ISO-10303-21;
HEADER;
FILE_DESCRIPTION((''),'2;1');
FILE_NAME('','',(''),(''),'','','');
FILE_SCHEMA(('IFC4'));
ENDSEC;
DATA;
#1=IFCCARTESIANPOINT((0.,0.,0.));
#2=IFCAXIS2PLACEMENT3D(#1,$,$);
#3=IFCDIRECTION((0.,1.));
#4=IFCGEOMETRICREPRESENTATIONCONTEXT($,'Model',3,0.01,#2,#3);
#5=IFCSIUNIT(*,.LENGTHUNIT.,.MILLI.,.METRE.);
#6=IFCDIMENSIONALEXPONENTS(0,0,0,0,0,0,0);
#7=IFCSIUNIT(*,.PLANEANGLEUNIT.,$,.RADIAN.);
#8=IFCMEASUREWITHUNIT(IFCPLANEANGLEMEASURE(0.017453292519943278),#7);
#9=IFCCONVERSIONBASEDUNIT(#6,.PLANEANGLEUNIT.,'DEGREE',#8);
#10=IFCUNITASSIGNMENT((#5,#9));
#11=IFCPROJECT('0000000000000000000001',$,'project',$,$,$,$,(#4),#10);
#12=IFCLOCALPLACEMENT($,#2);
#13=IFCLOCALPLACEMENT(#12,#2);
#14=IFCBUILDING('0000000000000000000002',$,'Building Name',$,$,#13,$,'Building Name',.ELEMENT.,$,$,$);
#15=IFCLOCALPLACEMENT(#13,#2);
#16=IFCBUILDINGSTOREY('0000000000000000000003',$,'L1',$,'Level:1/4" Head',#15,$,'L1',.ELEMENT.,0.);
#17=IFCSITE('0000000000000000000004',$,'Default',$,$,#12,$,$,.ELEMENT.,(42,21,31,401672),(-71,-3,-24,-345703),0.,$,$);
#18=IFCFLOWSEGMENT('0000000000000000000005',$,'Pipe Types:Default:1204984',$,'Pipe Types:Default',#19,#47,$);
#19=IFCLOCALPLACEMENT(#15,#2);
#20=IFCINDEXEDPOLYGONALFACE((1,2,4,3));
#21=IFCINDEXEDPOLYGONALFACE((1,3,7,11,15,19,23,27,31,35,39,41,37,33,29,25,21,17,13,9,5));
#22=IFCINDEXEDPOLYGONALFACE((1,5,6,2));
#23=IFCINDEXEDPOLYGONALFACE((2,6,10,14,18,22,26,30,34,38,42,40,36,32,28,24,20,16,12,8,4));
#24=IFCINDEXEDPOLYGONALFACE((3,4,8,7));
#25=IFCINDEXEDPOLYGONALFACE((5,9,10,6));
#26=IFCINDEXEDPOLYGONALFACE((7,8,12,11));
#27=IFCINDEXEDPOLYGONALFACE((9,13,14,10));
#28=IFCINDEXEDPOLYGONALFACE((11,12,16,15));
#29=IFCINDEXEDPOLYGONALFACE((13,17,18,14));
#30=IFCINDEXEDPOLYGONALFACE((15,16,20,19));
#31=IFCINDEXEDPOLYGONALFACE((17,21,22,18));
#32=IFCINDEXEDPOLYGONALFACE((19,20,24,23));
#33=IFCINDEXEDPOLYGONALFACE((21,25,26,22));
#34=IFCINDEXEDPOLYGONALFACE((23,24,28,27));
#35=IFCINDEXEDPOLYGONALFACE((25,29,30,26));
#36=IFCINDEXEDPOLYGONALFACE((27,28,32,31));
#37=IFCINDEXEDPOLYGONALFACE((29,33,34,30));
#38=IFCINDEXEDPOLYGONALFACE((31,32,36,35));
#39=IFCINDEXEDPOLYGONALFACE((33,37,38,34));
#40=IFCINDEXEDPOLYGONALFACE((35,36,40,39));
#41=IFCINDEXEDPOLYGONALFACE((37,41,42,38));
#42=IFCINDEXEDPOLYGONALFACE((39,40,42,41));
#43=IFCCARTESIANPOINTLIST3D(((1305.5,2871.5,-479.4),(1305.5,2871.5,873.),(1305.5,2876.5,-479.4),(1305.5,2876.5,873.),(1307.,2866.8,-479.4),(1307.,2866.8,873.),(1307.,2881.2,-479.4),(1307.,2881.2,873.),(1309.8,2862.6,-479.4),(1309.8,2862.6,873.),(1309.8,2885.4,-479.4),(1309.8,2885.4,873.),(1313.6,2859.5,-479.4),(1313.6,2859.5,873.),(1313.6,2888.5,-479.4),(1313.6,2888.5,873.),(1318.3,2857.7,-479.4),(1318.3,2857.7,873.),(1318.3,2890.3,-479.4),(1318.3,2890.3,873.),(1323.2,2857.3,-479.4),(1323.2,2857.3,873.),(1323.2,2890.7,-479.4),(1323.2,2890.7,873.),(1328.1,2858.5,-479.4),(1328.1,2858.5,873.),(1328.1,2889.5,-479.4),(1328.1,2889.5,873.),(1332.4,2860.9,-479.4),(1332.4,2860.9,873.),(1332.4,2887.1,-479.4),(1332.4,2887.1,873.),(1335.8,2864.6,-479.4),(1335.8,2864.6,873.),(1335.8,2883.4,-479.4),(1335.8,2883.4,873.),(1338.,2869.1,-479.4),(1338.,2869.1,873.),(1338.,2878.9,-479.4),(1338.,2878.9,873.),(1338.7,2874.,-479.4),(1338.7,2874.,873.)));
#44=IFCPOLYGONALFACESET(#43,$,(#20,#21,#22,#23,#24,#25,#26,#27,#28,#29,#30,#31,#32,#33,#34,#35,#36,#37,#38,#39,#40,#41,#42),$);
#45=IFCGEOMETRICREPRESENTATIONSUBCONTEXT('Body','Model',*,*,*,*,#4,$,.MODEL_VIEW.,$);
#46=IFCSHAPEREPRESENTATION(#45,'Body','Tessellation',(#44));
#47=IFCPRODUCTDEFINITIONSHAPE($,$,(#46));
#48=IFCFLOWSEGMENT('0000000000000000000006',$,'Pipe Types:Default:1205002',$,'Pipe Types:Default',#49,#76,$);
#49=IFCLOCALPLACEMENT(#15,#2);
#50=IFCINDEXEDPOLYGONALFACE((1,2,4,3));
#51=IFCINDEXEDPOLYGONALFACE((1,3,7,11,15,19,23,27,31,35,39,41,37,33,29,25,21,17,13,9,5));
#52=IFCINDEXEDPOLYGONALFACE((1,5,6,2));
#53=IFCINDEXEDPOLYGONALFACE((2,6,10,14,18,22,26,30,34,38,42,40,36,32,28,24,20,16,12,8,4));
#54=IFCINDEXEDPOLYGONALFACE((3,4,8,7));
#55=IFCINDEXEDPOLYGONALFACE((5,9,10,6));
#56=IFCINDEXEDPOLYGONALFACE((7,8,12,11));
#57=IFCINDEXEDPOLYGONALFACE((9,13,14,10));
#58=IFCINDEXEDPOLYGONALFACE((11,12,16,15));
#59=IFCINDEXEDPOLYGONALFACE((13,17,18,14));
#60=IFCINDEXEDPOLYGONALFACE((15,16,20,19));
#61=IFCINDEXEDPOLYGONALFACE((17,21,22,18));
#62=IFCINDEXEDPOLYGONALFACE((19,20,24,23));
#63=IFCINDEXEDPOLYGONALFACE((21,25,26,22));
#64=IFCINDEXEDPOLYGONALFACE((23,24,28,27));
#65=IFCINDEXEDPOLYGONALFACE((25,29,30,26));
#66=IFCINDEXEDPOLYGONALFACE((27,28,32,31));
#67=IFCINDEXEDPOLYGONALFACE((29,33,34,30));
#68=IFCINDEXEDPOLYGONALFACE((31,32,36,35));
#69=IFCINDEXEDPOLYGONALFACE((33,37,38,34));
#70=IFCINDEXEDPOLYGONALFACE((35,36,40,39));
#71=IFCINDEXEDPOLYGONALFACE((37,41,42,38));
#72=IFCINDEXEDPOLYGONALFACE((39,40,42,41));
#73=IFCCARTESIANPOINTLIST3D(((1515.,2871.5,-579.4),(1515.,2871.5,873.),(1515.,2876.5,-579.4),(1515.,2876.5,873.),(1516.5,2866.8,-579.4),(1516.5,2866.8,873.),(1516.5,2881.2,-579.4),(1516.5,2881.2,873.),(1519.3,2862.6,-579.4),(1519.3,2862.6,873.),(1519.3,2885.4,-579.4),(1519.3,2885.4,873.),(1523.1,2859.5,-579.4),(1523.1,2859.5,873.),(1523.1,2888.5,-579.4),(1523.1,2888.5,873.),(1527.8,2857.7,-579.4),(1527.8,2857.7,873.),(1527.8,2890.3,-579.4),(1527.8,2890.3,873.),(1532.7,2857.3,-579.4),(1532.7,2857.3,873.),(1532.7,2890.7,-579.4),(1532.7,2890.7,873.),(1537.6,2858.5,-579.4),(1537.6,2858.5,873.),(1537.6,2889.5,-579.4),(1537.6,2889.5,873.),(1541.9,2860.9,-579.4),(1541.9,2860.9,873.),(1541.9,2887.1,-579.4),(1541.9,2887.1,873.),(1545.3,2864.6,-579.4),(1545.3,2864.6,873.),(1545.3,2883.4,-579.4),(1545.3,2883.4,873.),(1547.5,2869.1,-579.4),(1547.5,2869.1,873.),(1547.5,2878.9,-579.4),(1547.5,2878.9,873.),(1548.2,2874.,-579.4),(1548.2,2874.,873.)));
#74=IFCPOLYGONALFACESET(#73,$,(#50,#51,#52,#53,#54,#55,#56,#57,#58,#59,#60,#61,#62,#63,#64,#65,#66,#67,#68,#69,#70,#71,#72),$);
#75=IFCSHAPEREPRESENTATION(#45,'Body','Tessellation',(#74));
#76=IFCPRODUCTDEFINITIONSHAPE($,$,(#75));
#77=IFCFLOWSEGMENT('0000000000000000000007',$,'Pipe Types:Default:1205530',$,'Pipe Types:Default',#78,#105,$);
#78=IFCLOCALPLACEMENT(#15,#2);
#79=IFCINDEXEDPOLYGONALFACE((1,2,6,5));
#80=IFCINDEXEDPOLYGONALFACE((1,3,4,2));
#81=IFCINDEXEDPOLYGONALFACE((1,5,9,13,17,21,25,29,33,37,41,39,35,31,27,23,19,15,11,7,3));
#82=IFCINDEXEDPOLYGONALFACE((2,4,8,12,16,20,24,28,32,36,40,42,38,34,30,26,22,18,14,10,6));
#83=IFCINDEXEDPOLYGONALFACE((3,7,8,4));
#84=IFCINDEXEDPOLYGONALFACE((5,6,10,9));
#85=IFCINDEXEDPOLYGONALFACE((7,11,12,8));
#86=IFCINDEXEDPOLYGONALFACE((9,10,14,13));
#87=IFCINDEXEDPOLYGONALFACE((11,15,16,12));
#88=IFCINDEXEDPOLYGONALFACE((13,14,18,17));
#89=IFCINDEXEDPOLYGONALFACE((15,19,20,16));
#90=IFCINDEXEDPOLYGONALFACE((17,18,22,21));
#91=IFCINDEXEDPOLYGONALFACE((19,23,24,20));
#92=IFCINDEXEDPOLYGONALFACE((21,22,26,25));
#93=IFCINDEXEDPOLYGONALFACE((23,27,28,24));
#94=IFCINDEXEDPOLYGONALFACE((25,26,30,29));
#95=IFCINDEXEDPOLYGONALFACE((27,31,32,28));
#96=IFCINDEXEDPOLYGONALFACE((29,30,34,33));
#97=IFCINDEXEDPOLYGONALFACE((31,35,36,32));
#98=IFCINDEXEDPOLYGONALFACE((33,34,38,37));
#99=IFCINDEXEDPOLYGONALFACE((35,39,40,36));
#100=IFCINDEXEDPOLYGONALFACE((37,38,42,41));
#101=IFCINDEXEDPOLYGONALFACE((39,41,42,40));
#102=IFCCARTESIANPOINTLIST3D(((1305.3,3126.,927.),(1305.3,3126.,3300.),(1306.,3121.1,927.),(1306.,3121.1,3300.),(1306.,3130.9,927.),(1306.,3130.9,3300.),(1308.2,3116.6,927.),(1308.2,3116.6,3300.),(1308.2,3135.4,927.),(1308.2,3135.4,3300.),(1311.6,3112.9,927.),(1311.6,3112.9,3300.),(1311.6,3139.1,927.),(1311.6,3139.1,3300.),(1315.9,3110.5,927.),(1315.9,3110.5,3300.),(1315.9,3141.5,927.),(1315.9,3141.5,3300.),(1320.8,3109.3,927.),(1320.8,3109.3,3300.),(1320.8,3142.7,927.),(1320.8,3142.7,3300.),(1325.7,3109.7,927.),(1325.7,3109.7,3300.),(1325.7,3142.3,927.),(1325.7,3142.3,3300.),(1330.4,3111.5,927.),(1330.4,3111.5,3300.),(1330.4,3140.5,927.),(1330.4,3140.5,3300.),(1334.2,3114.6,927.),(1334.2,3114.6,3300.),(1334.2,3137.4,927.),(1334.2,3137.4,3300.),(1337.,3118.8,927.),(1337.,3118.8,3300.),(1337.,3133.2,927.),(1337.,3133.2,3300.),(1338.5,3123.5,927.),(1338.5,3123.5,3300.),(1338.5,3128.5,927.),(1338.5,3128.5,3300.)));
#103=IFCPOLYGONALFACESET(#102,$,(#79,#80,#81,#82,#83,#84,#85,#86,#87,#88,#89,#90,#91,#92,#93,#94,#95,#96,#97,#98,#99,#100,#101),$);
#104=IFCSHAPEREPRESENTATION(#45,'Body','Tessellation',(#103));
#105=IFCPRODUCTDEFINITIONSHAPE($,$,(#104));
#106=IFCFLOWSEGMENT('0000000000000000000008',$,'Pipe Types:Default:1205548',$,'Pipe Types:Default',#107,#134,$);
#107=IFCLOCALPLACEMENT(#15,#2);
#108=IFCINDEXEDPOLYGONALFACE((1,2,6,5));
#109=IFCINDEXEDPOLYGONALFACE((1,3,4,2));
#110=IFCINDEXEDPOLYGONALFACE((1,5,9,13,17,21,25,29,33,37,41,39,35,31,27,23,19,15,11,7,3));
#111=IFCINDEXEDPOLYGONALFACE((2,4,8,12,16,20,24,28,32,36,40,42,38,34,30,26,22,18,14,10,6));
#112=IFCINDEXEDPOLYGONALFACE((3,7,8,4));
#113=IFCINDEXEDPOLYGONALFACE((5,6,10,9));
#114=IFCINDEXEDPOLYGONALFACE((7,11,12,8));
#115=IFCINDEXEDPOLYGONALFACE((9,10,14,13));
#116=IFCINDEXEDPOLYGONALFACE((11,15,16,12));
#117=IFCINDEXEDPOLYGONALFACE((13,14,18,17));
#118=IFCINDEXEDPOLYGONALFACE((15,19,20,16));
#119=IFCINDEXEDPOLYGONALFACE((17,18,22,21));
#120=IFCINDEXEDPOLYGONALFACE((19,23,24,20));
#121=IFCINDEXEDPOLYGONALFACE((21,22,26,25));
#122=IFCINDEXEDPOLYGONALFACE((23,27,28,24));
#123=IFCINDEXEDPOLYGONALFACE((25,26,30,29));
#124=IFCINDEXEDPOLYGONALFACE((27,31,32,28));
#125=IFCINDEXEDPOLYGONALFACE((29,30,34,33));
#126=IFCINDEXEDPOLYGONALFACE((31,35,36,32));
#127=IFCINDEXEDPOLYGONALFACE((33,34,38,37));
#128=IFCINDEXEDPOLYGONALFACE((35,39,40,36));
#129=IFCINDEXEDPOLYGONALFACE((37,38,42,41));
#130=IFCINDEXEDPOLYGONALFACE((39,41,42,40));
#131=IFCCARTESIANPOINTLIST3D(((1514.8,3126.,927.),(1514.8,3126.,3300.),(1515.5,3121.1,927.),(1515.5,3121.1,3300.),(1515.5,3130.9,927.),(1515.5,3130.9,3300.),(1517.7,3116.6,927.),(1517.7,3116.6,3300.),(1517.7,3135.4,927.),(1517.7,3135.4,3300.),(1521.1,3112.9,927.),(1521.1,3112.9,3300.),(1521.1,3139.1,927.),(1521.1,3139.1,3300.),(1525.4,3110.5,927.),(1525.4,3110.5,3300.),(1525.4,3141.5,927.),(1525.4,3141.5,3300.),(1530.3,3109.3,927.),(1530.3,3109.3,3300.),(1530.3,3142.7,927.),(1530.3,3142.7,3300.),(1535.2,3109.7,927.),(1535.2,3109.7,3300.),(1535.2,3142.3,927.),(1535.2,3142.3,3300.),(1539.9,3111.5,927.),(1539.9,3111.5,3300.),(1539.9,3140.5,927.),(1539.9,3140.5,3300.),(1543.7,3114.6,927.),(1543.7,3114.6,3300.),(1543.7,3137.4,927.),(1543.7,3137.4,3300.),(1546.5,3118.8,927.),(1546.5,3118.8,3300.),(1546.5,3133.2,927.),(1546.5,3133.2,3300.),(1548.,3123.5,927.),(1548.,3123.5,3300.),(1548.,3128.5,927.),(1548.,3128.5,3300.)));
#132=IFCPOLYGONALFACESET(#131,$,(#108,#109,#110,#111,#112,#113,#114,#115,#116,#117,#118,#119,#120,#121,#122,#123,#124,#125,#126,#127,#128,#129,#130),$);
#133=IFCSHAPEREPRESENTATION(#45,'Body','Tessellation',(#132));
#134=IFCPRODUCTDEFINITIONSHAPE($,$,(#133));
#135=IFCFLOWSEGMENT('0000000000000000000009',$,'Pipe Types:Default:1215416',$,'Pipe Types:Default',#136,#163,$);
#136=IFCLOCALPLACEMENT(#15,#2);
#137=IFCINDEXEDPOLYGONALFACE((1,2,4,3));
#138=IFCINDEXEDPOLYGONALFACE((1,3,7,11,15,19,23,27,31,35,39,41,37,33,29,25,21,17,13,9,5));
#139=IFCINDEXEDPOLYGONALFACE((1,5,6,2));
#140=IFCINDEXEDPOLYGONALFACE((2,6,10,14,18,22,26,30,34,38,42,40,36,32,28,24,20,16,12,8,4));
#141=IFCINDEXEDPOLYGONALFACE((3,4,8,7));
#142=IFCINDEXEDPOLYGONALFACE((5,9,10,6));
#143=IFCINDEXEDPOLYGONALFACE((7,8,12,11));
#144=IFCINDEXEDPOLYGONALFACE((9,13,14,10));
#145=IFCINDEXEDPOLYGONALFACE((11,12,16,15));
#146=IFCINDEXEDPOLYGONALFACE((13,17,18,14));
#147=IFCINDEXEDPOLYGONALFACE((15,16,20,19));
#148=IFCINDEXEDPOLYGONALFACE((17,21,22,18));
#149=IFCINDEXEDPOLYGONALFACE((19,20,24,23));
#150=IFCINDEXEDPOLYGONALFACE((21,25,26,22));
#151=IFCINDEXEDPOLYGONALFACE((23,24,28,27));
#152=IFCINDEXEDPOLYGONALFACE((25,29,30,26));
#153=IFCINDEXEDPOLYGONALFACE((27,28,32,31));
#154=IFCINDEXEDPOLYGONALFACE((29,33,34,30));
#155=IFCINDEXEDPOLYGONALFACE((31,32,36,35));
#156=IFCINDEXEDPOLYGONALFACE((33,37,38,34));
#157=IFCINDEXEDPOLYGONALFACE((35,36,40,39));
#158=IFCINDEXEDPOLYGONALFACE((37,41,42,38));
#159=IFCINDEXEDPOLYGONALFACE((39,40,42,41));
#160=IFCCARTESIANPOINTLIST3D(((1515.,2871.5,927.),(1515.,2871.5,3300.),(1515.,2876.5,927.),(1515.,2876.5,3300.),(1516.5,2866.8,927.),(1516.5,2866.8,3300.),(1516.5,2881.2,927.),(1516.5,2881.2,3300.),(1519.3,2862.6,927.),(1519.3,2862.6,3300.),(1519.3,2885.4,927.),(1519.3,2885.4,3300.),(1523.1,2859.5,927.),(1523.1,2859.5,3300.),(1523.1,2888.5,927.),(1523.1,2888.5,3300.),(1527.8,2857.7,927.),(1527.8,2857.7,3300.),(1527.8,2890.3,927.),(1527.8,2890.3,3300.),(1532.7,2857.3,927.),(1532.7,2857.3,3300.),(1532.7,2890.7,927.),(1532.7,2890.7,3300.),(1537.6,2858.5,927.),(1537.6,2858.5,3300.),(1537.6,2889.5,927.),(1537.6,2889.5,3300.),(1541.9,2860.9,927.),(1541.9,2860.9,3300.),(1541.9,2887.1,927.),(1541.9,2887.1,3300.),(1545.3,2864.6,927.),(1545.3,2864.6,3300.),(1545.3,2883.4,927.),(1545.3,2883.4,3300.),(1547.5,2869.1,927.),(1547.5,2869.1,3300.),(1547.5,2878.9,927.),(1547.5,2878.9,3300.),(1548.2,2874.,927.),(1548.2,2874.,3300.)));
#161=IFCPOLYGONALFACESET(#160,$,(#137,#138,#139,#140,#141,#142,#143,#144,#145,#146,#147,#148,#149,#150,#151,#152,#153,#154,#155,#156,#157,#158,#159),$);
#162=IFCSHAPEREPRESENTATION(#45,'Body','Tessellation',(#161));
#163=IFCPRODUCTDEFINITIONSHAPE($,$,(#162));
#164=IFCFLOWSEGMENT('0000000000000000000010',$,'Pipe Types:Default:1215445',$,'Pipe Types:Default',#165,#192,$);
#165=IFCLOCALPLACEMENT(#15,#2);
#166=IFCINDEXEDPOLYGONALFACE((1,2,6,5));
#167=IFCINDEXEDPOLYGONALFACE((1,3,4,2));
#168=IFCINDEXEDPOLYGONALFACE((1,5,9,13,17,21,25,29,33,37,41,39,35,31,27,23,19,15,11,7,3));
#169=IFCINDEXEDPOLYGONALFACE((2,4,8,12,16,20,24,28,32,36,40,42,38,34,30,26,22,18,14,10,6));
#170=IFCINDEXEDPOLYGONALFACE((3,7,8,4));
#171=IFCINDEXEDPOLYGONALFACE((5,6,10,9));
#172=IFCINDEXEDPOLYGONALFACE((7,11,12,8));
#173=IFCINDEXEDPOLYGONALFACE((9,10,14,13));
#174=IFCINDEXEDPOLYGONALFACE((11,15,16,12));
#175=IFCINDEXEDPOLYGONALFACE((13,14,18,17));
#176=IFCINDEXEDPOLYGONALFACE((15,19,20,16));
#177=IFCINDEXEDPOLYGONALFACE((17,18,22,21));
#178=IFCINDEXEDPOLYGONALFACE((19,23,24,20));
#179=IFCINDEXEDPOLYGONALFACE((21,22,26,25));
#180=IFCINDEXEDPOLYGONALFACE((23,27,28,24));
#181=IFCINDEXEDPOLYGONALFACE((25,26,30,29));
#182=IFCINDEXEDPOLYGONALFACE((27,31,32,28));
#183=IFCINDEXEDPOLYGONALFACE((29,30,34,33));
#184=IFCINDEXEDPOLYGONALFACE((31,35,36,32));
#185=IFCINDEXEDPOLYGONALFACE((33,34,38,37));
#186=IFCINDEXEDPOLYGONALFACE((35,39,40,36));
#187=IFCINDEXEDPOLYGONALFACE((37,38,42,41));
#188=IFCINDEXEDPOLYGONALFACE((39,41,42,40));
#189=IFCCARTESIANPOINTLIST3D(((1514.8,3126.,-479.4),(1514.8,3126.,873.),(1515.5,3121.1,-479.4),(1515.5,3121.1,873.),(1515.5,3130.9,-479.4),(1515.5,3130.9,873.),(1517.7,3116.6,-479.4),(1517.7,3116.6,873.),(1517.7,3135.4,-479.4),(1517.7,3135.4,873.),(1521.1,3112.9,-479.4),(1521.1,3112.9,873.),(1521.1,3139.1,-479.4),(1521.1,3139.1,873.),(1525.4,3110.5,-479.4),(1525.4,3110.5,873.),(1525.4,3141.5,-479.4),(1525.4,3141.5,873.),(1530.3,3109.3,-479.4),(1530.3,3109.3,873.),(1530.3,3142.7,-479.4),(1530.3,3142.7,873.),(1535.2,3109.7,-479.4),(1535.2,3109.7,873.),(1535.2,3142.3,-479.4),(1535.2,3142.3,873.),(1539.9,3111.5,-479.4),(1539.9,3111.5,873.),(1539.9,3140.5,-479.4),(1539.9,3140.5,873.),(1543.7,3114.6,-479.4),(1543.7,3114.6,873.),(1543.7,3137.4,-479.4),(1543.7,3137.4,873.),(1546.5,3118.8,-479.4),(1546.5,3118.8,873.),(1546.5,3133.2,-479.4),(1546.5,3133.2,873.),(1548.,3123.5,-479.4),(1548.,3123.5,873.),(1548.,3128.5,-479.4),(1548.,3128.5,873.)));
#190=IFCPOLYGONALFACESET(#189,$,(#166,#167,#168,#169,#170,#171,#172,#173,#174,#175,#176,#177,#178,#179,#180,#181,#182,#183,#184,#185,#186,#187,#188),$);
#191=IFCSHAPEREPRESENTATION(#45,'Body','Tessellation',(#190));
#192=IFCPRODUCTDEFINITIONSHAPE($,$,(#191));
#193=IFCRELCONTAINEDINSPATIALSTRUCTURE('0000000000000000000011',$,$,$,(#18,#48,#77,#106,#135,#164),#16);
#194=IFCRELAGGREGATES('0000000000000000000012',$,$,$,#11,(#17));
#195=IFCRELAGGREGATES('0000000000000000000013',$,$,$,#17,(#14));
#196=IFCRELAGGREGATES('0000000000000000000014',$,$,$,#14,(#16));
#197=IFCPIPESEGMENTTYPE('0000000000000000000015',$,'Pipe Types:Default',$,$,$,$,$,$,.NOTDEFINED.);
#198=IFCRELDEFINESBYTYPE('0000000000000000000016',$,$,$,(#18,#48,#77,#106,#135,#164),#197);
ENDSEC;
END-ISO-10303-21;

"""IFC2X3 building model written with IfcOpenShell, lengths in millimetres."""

from ifc_helpers import new_model, entity, si_unit, converted_unit, direction, frame, origin, origin_2d_with_axis, place, context, subcontext, project, spatial, circle, extrude, type_object, element, save


model = new_model("IFC2X3")

# Units and contexts
model_context = context("Model", 3, precision=0.01, world=origin(), true_north=direction((0.0, 1.0)))
body_context = subcontext(model_context, "Body", "Model", "MODEL_VIEW")
ifc_project = project(units=[si_unit("LENGTHUNIT", "METRE", prefix="MILLI"), converted_unit("PLANEANGLEUNIT", "DEGREE", entity("IfcPlaneAngleMeasure", 0.017453292519943278), si_unit("PLANEANGLEUNIT", "RADIAN"), dimensions=[0, 0, 0, 0, 0, 0, 0])], contexts=[model_context])

# Site, building, storey
site_placement = place(None, origin())
site = spatial("IfcSite", under=ifc_project, at=site_placement, Name="Default", CompositionType="ELEMENT", RefLatitude=(42, 21, 31, 401672), RefLongitude=(-71, -3, -24, -345703), RefElevation=0.0)
building_placement = place(site_placement, origin())
building = spatial("IfcBuilding", under=site, at=building_placement, Name="Building Name", LongName="Building Name", CompositionType="ELEMENT")
storey_placement = place(building_placement, origin())
storey = spatial("IfcBuildingStorey", under=building, at=storey_placement, Name="L1", ObjectType="Level:1/4\" Head", LongName="L1", CompositionType="ELEMENT", Elevation=0.0)

# Flow segments
pipe_segment_type = type_object("IfcPipeSegmentType", Name="Pipe Types:Default", PredefinedType="NOTDEFINED")
flow_segment_1_placement = place(storey_placement, origin())
element("IfcFlowSegment", 1, at=flow_segment_1_placement, inside=storey, type_object=pipe_segment_type, Name="Pipe Types:Default:1204984", ObjectType="Pipe Types:Default", context=body_context, shape_type="SweptSolid", body=[
    extrude(circle(Radius=16.7, at=origin_2d_with_axis()), frame((1322.0, 2874.0, -479.4)), (0.0, 0.0, 1.0), 1352.4),
])
flow_segment_2_placement = place(storey_placement, origin())
element("IfcFlowSegment", 2, at=flow_segment_2_placement, inside=storey, type_object=pipe_segment_type, Name="Pipe Types:Default:1205002", ObjectType="Pipe Types:Default", context=body_context, shape_type="SweptSolid", body=[
    extrude(circle(Radius=16.7, at=origin_2d_with_axis()), frame((1531.5, 2874.0, -579.4)), (0.0, 0.0, 1.0), 1452.4),
])
flow_segment_3_placement = place(storey_placement, origin())
element("IfcFlowSegment", 3, at=flow_segment_3_placement, inside=storey, type_object=pipe_segment_type, Name="Pipe Types:Default:1205530", ObjectType="Pipe Types:Default", context=body_context, shape_type="SweptSolid", body=[
    extrude(circle(Radius=16.7, at=origin_2d_with_axis()), frame((1322.0, 3126.0, 927.0), z_axis=(0.0, 0.0, 1.0), x_axis=(-1.0, 0.0, 0.0)), (0.0, 0.0, 1.0), 2373.0),
])
flow_segment_4_placement = place(storey_placement, origin())
element("IfcFlowSegment", 4, at=flow_segment_4_placement, inside=storey, type_object=pipe_segment_type, Name="Pipe Types:Default:1205548", ObjectType="Pipe Types:Default", context=body_context, shape_type="SweptSolid", body=[
    extrude(circle(Radius=16.7, at=origin_2d_with_axis()), frame((1531.5, 3126.0, 927.0), z_axis=(0.0, 0.0, 1.0), x_axis=(-1.0, 0.0, 0.0)), (0.0, 0.0, 1.0), 2373.0),
])
flow_segment_5_placement = place(storey_placement, origin())
element("IfcFlowSegment", 5, at=flow_segment_5_placement, inside=storey, type_object=pipe_segment_type, Name="Pipe Types:Default:1215416", ObjectType="Pipe Types:Default", context=body_context, shape_type="SweptSolid", body=[
    extrude(circle(Radius=16.7, at=origin_2d_with_axis()), frame((1531.5, 2874.0, 927.0)), (0.0, 0.0, 1.0), 2373.0),
])
flow_segment_6_placement = place(storey_placement, origin())
element("IfcFlowSegment", 6, at=flow_segment_6_placement, inside=storey, type_object=pipe_segment_type, Name="Pipe Types:Default:1215445", ObjectType="Pipe Types:Default", context=body_context, shape_type="SweptSolid", body=[
    extrude(circle(Radius=16.7, at=origin_2d_with_axis()), frame((1531.5, 3126.0, -479.4), z_axis=(0.0, 0.0, 1.0), x_axis=(-1.0, 0.0, 0.0)), (0.0, 0.0, 1.0), 1352.4),
])

save(model, "model.ifc")
